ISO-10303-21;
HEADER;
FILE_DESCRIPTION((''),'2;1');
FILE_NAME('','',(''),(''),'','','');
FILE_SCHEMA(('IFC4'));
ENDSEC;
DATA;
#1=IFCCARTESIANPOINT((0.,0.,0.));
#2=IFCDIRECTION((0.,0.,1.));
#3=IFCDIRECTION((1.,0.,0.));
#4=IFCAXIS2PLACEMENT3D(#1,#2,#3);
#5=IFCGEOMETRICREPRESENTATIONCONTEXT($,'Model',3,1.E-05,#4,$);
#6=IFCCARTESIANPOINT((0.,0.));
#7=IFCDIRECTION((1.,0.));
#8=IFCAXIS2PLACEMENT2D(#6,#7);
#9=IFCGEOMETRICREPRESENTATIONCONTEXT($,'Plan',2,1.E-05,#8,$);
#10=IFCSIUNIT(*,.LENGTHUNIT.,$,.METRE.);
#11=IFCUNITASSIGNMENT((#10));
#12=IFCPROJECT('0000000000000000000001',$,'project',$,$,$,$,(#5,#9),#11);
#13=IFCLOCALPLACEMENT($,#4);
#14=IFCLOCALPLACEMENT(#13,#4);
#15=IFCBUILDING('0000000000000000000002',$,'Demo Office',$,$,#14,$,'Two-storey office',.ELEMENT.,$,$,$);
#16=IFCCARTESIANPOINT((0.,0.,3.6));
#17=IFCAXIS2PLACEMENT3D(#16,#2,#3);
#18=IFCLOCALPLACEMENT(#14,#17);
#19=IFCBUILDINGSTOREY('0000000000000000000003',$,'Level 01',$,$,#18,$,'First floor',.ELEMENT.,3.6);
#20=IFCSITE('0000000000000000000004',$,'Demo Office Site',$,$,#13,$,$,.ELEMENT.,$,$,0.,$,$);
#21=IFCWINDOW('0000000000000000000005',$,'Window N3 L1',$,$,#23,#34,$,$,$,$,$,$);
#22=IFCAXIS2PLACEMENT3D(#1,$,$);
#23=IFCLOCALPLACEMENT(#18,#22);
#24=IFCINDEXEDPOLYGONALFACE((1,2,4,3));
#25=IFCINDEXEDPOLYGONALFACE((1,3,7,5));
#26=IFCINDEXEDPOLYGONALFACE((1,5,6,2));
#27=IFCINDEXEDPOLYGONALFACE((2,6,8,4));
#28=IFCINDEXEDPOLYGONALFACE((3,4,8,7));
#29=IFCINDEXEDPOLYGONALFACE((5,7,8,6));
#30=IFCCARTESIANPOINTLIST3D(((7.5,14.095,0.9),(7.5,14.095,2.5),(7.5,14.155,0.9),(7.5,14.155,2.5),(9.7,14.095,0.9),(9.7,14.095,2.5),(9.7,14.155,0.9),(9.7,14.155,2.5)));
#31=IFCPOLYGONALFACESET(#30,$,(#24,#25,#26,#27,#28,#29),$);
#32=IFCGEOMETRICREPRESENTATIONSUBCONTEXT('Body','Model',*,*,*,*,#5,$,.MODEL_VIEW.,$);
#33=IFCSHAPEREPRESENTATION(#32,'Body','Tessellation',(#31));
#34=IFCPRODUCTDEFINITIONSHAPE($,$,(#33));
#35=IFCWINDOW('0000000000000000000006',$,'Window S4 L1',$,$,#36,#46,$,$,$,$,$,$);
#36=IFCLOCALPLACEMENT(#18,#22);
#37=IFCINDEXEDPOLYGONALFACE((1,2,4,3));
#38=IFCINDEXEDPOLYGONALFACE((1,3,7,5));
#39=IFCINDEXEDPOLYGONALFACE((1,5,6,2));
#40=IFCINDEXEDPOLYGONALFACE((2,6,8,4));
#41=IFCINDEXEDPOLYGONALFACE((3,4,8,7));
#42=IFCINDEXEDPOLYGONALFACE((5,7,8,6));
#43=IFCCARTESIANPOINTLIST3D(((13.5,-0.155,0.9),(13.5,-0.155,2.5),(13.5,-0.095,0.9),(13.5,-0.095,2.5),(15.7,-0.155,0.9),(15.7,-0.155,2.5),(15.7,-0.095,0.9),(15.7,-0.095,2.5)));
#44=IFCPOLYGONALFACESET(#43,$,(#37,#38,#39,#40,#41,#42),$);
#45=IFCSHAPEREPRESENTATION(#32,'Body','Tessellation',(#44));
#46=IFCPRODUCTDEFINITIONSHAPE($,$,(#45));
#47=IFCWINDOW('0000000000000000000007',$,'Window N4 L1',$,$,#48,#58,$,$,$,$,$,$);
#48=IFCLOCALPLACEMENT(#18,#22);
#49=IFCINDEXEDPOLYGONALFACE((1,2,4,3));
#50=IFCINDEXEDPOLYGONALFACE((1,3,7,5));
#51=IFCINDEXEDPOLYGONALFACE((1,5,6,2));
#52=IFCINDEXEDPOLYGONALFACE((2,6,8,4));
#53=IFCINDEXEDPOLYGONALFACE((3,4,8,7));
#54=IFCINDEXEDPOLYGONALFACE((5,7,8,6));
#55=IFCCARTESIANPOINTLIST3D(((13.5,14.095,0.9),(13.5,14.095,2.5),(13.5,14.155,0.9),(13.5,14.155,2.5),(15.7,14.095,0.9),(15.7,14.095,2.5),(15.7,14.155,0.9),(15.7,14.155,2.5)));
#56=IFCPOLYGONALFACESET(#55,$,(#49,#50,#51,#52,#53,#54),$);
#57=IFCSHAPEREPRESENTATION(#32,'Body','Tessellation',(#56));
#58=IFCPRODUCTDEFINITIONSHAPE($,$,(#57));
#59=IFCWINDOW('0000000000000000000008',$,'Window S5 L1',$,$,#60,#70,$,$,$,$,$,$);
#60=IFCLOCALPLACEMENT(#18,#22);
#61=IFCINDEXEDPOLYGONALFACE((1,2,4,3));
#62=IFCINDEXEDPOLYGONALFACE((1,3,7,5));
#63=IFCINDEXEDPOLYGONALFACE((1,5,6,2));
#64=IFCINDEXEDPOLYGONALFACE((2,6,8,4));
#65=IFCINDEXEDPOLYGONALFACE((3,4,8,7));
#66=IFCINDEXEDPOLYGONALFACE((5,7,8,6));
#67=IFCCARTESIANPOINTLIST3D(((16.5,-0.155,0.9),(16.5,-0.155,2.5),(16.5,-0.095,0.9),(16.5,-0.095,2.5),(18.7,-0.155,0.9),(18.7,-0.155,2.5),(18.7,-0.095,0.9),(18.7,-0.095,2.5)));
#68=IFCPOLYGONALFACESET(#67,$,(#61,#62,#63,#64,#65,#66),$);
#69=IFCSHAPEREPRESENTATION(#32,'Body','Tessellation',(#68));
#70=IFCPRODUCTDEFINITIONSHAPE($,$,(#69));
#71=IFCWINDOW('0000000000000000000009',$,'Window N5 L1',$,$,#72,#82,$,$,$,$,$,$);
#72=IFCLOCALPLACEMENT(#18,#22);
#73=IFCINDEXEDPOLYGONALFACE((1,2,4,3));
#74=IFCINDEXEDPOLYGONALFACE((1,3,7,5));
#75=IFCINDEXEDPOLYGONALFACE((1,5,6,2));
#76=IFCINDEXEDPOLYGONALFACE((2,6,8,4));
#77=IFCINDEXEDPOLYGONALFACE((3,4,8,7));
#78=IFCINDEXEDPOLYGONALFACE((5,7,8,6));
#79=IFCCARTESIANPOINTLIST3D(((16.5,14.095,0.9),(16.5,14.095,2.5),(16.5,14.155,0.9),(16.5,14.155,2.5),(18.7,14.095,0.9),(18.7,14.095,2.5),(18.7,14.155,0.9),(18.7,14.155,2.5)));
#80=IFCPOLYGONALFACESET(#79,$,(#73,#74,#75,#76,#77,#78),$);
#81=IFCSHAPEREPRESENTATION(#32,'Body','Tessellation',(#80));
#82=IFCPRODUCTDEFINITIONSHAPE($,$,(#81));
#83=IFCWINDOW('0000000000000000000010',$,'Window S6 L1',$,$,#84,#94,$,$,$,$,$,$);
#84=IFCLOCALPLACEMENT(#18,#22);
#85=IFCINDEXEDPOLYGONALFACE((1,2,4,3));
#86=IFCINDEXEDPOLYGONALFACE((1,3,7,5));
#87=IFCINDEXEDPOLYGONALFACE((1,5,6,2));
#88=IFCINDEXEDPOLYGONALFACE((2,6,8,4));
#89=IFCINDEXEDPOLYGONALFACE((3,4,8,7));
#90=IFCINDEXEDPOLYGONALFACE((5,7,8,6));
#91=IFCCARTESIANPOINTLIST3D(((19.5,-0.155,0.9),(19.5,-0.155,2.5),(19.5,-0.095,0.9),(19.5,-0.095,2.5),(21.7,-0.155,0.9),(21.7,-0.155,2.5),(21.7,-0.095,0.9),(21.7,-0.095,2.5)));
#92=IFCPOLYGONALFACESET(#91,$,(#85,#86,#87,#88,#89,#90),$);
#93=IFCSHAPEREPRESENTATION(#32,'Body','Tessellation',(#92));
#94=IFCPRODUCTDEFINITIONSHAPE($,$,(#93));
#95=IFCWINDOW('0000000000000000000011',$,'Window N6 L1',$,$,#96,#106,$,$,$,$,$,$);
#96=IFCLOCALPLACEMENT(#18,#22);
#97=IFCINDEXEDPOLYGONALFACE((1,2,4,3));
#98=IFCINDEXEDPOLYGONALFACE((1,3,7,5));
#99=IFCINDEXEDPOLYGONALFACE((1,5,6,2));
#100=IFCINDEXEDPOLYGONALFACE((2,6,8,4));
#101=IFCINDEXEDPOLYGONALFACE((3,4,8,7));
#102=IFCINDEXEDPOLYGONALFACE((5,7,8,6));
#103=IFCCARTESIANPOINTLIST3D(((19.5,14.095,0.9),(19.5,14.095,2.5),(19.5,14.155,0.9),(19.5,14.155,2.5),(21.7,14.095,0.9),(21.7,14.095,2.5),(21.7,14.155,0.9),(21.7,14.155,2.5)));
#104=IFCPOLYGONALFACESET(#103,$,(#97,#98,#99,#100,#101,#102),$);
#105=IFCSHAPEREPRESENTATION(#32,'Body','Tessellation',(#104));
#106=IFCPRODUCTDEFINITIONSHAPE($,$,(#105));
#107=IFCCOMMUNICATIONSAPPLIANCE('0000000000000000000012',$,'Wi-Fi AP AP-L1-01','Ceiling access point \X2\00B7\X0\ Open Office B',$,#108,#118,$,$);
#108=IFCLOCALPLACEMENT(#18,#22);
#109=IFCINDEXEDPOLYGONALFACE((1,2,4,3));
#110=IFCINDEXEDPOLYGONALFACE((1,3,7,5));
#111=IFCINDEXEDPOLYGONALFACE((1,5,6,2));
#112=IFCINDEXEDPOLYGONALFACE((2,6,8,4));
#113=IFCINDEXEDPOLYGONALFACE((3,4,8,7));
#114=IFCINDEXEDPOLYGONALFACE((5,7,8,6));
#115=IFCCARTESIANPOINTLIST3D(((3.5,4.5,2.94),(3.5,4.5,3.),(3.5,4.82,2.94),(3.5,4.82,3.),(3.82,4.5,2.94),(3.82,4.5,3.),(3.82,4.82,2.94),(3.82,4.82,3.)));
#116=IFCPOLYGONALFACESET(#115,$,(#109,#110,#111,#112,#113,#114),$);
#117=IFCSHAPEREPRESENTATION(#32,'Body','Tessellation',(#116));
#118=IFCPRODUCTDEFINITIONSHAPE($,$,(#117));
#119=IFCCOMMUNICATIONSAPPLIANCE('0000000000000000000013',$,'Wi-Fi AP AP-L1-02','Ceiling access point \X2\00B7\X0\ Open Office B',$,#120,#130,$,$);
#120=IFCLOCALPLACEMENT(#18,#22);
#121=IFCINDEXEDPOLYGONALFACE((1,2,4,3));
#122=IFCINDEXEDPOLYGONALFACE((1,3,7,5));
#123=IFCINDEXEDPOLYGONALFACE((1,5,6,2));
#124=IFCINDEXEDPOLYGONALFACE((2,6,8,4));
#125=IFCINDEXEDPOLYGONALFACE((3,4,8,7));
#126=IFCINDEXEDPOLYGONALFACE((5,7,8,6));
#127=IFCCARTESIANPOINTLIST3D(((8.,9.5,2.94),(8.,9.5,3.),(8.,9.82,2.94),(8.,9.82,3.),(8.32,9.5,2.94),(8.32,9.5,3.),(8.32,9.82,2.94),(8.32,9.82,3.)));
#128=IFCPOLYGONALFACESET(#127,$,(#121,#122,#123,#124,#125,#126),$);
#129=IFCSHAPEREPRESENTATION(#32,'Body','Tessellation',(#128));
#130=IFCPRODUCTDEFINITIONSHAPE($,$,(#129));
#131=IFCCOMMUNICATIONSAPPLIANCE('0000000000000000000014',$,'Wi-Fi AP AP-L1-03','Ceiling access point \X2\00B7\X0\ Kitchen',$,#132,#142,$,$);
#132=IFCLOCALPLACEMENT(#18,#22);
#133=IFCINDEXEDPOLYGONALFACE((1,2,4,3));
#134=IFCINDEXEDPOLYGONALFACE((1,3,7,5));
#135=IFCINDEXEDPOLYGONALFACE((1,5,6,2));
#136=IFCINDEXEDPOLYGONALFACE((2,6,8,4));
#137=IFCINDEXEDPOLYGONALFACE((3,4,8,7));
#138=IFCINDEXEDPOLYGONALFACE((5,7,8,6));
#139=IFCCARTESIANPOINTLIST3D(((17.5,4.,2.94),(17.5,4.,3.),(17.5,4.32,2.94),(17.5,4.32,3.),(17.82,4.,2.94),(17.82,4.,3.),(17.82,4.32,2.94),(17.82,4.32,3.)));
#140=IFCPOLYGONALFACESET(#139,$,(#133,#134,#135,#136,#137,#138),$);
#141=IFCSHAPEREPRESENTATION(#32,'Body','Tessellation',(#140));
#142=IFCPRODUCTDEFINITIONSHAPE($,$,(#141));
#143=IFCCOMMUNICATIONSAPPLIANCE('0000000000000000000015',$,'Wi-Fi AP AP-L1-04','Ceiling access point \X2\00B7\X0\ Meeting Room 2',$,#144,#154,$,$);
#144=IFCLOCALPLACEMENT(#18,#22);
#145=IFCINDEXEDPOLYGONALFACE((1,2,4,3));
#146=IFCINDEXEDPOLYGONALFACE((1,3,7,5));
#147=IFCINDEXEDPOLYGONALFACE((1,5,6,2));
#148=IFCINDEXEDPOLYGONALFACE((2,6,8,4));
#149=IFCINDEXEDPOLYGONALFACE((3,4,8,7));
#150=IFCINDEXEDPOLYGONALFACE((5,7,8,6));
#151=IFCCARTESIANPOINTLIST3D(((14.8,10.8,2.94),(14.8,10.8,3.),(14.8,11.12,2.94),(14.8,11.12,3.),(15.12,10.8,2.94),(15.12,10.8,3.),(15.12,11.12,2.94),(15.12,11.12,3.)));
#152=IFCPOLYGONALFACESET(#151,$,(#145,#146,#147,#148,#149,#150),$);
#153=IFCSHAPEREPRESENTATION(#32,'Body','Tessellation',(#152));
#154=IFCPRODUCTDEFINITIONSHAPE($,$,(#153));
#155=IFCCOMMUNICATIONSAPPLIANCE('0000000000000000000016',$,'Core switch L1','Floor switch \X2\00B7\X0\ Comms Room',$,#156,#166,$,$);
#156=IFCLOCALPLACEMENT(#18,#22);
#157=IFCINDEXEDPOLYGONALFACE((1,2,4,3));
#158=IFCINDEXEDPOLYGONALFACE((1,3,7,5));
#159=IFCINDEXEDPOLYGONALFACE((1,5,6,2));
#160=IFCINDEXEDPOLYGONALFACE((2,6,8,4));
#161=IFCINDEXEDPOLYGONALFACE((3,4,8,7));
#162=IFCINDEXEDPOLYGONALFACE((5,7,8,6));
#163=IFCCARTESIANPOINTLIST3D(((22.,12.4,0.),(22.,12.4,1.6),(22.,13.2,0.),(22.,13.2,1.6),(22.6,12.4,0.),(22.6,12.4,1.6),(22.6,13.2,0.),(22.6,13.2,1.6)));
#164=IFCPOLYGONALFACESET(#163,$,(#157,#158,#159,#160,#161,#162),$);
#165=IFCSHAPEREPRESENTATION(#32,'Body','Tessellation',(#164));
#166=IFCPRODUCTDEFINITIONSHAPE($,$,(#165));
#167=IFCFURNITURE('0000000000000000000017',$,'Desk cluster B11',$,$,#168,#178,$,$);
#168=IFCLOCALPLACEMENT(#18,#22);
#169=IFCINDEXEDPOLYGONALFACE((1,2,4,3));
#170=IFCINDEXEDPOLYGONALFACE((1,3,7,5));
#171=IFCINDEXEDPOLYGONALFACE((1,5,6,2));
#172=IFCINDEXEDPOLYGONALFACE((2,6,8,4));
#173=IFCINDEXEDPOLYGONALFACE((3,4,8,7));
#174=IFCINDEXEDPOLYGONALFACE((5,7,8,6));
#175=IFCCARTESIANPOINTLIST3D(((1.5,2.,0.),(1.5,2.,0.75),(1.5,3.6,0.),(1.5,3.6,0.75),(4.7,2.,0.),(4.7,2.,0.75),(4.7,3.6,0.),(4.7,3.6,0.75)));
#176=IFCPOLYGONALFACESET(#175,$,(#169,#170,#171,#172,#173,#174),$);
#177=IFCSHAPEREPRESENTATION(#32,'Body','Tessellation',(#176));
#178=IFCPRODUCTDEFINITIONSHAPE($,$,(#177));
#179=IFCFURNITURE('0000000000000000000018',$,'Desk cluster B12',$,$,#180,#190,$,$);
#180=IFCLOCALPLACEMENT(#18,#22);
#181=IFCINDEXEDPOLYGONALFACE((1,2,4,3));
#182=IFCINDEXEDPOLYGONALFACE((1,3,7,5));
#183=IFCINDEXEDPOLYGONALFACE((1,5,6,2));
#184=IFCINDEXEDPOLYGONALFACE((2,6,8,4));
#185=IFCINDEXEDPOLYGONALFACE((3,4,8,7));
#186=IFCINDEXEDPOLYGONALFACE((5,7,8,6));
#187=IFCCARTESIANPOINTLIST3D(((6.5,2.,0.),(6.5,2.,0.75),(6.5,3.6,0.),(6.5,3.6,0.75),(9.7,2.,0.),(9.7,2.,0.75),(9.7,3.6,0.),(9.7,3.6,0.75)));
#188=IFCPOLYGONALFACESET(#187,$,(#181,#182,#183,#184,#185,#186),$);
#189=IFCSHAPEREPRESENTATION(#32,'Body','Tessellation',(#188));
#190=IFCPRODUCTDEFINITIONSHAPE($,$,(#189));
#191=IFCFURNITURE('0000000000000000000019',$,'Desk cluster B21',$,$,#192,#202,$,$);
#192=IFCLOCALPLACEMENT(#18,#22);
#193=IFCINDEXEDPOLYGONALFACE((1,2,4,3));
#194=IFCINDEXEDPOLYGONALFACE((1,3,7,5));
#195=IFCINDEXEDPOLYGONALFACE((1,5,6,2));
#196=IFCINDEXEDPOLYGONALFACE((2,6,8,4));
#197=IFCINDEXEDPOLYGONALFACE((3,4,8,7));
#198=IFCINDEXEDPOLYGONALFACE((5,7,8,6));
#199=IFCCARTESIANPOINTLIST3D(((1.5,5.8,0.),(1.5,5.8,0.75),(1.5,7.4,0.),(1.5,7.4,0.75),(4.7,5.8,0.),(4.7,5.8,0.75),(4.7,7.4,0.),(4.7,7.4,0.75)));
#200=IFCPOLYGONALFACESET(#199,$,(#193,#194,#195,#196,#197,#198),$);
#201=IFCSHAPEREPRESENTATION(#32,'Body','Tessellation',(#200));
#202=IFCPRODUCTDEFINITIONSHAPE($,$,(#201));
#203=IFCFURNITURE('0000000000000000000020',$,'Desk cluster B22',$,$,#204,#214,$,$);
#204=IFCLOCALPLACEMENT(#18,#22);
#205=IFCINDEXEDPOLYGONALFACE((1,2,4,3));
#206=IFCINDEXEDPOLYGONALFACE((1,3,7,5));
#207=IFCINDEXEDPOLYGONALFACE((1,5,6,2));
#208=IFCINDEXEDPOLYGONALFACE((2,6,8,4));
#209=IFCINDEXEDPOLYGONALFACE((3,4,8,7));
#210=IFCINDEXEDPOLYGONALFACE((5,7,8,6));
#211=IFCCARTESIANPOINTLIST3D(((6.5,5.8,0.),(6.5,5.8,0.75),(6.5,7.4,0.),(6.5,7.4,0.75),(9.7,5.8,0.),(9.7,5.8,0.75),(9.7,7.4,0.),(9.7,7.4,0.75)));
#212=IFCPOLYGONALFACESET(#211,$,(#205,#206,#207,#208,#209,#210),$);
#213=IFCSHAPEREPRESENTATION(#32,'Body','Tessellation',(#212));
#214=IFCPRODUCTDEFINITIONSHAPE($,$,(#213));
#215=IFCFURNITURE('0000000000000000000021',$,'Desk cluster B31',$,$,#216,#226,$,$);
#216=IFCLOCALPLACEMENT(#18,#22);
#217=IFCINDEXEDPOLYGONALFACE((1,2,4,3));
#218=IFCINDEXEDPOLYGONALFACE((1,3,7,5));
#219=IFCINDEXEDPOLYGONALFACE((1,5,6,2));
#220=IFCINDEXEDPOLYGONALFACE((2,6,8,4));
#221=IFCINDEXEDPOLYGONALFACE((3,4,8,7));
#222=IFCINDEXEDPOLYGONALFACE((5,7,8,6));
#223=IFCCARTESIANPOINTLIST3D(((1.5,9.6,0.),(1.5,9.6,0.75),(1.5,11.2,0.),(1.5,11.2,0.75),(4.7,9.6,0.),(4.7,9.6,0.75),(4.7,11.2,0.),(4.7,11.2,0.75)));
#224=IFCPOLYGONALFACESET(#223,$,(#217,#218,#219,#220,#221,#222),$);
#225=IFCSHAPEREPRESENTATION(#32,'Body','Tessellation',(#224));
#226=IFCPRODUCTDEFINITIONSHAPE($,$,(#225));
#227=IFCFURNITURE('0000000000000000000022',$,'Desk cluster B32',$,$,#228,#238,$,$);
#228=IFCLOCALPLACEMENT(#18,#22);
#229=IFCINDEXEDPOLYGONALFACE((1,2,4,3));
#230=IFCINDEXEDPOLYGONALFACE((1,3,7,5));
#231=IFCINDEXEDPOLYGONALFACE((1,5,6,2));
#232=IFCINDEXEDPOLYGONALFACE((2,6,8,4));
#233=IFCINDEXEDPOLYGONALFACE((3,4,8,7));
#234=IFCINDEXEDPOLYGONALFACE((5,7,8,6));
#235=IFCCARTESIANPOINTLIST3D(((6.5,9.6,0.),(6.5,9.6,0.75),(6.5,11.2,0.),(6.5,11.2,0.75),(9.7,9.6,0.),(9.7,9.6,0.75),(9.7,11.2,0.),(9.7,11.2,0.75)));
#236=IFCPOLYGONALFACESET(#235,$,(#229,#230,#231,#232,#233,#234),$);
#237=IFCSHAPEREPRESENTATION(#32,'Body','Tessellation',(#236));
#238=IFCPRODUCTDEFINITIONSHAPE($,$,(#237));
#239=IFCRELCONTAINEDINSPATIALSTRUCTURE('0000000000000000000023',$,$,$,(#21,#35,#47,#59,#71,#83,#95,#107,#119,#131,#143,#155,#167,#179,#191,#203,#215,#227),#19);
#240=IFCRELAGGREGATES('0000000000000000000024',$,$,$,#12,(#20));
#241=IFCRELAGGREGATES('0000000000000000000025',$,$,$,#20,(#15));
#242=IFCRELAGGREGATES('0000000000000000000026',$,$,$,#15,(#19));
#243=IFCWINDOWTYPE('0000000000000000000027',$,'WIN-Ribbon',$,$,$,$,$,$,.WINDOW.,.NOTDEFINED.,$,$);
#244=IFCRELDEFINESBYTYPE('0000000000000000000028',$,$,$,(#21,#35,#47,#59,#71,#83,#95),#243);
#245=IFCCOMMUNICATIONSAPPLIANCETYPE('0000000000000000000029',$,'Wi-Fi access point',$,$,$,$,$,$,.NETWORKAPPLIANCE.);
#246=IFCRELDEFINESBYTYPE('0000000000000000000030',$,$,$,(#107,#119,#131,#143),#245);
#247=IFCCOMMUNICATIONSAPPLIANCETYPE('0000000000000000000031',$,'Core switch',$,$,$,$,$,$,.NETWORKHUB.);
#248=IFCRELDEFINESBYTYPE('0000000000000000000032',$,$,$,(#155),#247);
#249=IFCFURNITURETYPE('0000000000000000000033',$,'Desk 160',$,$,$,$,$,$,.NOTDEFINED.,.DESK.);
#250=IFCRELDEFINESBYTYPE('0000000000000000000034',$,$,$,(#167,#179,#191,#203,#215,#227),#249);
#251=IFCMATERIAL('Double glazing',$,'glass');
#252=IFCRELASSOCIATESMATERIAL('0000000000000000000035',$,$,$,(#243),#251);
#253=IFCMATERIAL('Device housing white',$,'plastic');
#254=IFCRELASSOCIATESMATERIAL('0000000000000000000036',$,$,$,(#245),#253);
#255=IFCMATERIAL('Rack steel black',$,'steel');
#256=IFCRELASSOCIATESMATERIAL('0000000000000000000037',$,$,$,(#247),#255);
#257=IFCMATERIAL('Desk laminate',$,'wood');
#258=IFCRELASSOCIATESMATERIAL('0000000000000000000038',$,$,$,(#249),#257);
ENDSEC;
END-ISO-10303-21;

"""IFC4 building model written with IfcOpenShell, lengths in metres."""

from ifc_helpers import new_model, si_unit, frame, origin_with_axes, origin_2d_with_axis, place, context, subcontext, project, spatial, line, indexed_curve, outline, extrude, material, type_object, element, save


model = new_model("IFC4")

# Units and contexts
model_context = context("Model", 3, precision=1e-05, world=origin_with_axes())
plan_context = context("Plan", 2, precision=1e-05, world=origin_2d_with_axis())
body_context = subcontext(model_context, "Body", "Model", "MODEL_VIEW")
ifc_project = project(units=[si_unit("LENGTHUNIT", "METRE")], contexts=[model_context, plan_context])

# Site, building, storey
site_placement = place(None, origin_with_axes())
site = spatial("IfcSite", under=ifc_project, at=site_placement, Name="Demo Office Site", CompositionType="ELEMENT", RefElevation=0.0)
building_placement = place(site_placement, origin_with_axes())
building = spatial("IfcBuilding", under=site, at=building_placement, Name="Demo Office", LongName="Two-storey office", CompositionType="ELEMENT")
storey_placement = place(building_placement, frame((0.0, 0.0, 3.6), z_axis=(0.0, 0.0, 1.0), x_axis=(1.0, 0.0, 0.0)))
storey = spatial("IfcBuildingStorey", under=building, at=storey_placement, Name="Level 01", LongName="First floor", CompositionType="ELEMENT", Elevation=3.6)

# Windows
ifc_material_1 = material(Name="Double glazing", Category="glass")
window_type = type_object("IfcWindowType", Name="WIN-Ribbon", PartitioningType="NOTDEFINED", PredefinedType="WINDOW", material=ifc_material_1)
for number, where, z_axis, x_axis, name in (
    (1, (7.5, 14.095, 0.9), (0.0, 0.0, 1.0), (1.0, 0.0, 0.0), "Window N3 L1"),
    (2, (13.5, -0.155, 0.9), (0.0, 0.0, 1.0), (1.0, 0.0, 0.0), "Window S4 L1"),
    (3, (13.5, 14.095, 0.9), (0.0, 0.0, 1.0), (1.0, 0.0, 0.0), "Window N4 L1"),
    (4, (16.5, -0.155, 0.9), (0.0, 0.0, 1.0), (1.0, 0.0, 0.0), "Window S5 L1"),
    (5, (16.5, 14.095, 0.9), (0.0, 0.0, 1.0), (1.0, 0.0, 0.0), "Window N5 L1"),
    (6, (19.5, -0.155, 0.9), (0.0, 0.0, 1.0), (1.0, 0.0, 0.0), "Window S6 L1"),
    (7, (19.5, 14.095, 0.9), (0.0, 0.0, 1.0), (1.0, 0.0, 0.0), "Window N6 L1"),
):
    element("IfcWindow", number, at=place(storey_placement, frame(where, z_axis=z_axis, x_axis=x_axis)), inside=storey, type_object=window_type, Name=name, context=body_context, shape_type="SweptSolid", body=[
        extrude(outline(indexed_curve([(0.0, 0.0), (2.2, 0.0), (2.2, 0.06), (0.0, 0.06)], segments=[line(1, 2, 3, 4, 1)])), origin_with_axes(), (0.0, 0.0, 1.0), 1.6),
    ])

# Communications appliances
ifc_material_2 = material(Name="Device housing white", Category="plastic")
communications_appliance_type_1 = type_object("IfcCommunicationsApplianceType", Name="Wi-Fi access point", PredefinedType="NETWORKAPPLIANCE", material=ifc_material_2)
for number, where, z_axis, x_axis, name, description in (
    (8, (3.5, 4.5, 2.94), (0.0, 0.0, 1.0), (1.0, 0.0, 0.0), "Wi-Fi AP AP-L1-01", "Ceiling access point · Open Office B"),
    (9, (8.0, 9.5, 2.94), (0.0, 0.0, 1.0), (1.0, 0.0, 0.0), "Wi-Fi AP AP-L1-02", "Ceiling access point · Open Office B"),
    (10, (17.5, 4.0, 2.94), (0.0, 0.0, 1.0), (1.0, 0.0, 0.0), "Wi-Fi AP AP-L1-03", "Ceiling access point · Kitchen"),
    (11, (14.8, 10.8, 2.94), (0.0, 0.0, 1.0), (1.0, 0.0, 0.0), "Wi-Fi AP AP-L1-04", "Ceiling access point · Meeting Room 2"),
):
    element("IfcCommunicationsAppliance", number, at=place(storey_placement, frame(where, z_axis=z_axis, x_axis=x_axis)), inside=storey, type_object=communications_appliance_type_1, Name=name, Description=description, context=body_context, shape_type="SweptSolid", body=[
        extrude(outline(indexed_curve([(0.0, 0.0), (0.32, 0.0), (0.32, 0.32), (0.0, 0.32)], segments=[line(1, 2, 3, 4, 1)])), origin_with_axes(), (0.0, 0.0, 1.0), 0.06),
    ])
ifc_material_3 = material(Name="Rack steel black", Category="steel")
communications_appliance_type_2 = type_object("IfcCommunicationsApplianceType", Name="Core switch", PredefinedType="NETWORKHUB", material=ifc_material_3)
communications_appliance_placement = place(storey_placement, frame((22.0, 12.4, 0.0), z_axis=(0.0, 0.0, 1.0), x_axis=(1.0, 0.0, 0.0)))
element("IfcCommunicationsAppliance", 12, at=communications_appliance_placement, inside=storey, type_object=communications_appliance_type_2, Name="Core switch L1", Description="Floor switch · Comms Room", context=body_context, shape_type="SweptSolid", body=[
    extrude(outline(indexed_curve([(0.0, 0.0), (0.6, 0.0), (0.6, 0.8), (0.0, 0.8)], segments=[line(1, 2, 3, 4, 1)])), origin_with_axes(), (0.0, 0.0, 1.0), 1.6),
])

# Furniture
ifc_material_4 = material(Name="Desk laminate", Category="wood")
furniture_type = type_object("IfcFurnitureType", Name="Desk 160", AssemblyPlace="NOTDEFINED", PredefinedType="DESK", material=ifc_material_4)
for number, where, z_axis, x_axis, name in (
    (13, (1.5, 2.0, 0.0), (0.0, 0.0, 1.0), (1.0, 0.0, 0.0), "Desk cluster B11"),
    (14, (6.5, 2.0, 0.0), (0.0, 0.0, 1.0), (1.0, 0.0, 0.0), "Desk cluster B12"),
    (15, (1.5, 5.8, 0.0), (0.0, 0.0, 1.0), (1.0, 0.0, 0.0), "Desk cluster B21"),
    (16, (6.5, 5.8, 0.0), (0.0, 0.0, 1.0), (1.0, 0.0, 0.0), "Desk cluster B22"),
    (17, (1.5, 9.6, 0.0), (0.0, 0.0, 1.0), (1.0, 0.0, 0.0), "Desk cluster B31"),
    (18, (6.5, 9.6, 0.0), (0.0, 0.0, 1.0), (1.0, 0.0, 0.0), "Desk cluster B32"),
):
    element("IfcFurniture", number, at=place(storey_placement, frame(where, z_axis=z_axis, x_axis=x_axis)), inside=storey, type_object=furniture_type, Name=name, context=body_context, shape_type="SweptSolid", body=[
        extrude(outline(indexed_curve([(0.0, 0.0), (3.2, 0.0), (3.2, 1.6), (0.0, 1.6)], segments=[line(1, 2, 3, 4, 1)])), origin_with_axes(), (0.0, 0.0, 1.0), 0.75),
    ])

save(model, "model.ifc")
